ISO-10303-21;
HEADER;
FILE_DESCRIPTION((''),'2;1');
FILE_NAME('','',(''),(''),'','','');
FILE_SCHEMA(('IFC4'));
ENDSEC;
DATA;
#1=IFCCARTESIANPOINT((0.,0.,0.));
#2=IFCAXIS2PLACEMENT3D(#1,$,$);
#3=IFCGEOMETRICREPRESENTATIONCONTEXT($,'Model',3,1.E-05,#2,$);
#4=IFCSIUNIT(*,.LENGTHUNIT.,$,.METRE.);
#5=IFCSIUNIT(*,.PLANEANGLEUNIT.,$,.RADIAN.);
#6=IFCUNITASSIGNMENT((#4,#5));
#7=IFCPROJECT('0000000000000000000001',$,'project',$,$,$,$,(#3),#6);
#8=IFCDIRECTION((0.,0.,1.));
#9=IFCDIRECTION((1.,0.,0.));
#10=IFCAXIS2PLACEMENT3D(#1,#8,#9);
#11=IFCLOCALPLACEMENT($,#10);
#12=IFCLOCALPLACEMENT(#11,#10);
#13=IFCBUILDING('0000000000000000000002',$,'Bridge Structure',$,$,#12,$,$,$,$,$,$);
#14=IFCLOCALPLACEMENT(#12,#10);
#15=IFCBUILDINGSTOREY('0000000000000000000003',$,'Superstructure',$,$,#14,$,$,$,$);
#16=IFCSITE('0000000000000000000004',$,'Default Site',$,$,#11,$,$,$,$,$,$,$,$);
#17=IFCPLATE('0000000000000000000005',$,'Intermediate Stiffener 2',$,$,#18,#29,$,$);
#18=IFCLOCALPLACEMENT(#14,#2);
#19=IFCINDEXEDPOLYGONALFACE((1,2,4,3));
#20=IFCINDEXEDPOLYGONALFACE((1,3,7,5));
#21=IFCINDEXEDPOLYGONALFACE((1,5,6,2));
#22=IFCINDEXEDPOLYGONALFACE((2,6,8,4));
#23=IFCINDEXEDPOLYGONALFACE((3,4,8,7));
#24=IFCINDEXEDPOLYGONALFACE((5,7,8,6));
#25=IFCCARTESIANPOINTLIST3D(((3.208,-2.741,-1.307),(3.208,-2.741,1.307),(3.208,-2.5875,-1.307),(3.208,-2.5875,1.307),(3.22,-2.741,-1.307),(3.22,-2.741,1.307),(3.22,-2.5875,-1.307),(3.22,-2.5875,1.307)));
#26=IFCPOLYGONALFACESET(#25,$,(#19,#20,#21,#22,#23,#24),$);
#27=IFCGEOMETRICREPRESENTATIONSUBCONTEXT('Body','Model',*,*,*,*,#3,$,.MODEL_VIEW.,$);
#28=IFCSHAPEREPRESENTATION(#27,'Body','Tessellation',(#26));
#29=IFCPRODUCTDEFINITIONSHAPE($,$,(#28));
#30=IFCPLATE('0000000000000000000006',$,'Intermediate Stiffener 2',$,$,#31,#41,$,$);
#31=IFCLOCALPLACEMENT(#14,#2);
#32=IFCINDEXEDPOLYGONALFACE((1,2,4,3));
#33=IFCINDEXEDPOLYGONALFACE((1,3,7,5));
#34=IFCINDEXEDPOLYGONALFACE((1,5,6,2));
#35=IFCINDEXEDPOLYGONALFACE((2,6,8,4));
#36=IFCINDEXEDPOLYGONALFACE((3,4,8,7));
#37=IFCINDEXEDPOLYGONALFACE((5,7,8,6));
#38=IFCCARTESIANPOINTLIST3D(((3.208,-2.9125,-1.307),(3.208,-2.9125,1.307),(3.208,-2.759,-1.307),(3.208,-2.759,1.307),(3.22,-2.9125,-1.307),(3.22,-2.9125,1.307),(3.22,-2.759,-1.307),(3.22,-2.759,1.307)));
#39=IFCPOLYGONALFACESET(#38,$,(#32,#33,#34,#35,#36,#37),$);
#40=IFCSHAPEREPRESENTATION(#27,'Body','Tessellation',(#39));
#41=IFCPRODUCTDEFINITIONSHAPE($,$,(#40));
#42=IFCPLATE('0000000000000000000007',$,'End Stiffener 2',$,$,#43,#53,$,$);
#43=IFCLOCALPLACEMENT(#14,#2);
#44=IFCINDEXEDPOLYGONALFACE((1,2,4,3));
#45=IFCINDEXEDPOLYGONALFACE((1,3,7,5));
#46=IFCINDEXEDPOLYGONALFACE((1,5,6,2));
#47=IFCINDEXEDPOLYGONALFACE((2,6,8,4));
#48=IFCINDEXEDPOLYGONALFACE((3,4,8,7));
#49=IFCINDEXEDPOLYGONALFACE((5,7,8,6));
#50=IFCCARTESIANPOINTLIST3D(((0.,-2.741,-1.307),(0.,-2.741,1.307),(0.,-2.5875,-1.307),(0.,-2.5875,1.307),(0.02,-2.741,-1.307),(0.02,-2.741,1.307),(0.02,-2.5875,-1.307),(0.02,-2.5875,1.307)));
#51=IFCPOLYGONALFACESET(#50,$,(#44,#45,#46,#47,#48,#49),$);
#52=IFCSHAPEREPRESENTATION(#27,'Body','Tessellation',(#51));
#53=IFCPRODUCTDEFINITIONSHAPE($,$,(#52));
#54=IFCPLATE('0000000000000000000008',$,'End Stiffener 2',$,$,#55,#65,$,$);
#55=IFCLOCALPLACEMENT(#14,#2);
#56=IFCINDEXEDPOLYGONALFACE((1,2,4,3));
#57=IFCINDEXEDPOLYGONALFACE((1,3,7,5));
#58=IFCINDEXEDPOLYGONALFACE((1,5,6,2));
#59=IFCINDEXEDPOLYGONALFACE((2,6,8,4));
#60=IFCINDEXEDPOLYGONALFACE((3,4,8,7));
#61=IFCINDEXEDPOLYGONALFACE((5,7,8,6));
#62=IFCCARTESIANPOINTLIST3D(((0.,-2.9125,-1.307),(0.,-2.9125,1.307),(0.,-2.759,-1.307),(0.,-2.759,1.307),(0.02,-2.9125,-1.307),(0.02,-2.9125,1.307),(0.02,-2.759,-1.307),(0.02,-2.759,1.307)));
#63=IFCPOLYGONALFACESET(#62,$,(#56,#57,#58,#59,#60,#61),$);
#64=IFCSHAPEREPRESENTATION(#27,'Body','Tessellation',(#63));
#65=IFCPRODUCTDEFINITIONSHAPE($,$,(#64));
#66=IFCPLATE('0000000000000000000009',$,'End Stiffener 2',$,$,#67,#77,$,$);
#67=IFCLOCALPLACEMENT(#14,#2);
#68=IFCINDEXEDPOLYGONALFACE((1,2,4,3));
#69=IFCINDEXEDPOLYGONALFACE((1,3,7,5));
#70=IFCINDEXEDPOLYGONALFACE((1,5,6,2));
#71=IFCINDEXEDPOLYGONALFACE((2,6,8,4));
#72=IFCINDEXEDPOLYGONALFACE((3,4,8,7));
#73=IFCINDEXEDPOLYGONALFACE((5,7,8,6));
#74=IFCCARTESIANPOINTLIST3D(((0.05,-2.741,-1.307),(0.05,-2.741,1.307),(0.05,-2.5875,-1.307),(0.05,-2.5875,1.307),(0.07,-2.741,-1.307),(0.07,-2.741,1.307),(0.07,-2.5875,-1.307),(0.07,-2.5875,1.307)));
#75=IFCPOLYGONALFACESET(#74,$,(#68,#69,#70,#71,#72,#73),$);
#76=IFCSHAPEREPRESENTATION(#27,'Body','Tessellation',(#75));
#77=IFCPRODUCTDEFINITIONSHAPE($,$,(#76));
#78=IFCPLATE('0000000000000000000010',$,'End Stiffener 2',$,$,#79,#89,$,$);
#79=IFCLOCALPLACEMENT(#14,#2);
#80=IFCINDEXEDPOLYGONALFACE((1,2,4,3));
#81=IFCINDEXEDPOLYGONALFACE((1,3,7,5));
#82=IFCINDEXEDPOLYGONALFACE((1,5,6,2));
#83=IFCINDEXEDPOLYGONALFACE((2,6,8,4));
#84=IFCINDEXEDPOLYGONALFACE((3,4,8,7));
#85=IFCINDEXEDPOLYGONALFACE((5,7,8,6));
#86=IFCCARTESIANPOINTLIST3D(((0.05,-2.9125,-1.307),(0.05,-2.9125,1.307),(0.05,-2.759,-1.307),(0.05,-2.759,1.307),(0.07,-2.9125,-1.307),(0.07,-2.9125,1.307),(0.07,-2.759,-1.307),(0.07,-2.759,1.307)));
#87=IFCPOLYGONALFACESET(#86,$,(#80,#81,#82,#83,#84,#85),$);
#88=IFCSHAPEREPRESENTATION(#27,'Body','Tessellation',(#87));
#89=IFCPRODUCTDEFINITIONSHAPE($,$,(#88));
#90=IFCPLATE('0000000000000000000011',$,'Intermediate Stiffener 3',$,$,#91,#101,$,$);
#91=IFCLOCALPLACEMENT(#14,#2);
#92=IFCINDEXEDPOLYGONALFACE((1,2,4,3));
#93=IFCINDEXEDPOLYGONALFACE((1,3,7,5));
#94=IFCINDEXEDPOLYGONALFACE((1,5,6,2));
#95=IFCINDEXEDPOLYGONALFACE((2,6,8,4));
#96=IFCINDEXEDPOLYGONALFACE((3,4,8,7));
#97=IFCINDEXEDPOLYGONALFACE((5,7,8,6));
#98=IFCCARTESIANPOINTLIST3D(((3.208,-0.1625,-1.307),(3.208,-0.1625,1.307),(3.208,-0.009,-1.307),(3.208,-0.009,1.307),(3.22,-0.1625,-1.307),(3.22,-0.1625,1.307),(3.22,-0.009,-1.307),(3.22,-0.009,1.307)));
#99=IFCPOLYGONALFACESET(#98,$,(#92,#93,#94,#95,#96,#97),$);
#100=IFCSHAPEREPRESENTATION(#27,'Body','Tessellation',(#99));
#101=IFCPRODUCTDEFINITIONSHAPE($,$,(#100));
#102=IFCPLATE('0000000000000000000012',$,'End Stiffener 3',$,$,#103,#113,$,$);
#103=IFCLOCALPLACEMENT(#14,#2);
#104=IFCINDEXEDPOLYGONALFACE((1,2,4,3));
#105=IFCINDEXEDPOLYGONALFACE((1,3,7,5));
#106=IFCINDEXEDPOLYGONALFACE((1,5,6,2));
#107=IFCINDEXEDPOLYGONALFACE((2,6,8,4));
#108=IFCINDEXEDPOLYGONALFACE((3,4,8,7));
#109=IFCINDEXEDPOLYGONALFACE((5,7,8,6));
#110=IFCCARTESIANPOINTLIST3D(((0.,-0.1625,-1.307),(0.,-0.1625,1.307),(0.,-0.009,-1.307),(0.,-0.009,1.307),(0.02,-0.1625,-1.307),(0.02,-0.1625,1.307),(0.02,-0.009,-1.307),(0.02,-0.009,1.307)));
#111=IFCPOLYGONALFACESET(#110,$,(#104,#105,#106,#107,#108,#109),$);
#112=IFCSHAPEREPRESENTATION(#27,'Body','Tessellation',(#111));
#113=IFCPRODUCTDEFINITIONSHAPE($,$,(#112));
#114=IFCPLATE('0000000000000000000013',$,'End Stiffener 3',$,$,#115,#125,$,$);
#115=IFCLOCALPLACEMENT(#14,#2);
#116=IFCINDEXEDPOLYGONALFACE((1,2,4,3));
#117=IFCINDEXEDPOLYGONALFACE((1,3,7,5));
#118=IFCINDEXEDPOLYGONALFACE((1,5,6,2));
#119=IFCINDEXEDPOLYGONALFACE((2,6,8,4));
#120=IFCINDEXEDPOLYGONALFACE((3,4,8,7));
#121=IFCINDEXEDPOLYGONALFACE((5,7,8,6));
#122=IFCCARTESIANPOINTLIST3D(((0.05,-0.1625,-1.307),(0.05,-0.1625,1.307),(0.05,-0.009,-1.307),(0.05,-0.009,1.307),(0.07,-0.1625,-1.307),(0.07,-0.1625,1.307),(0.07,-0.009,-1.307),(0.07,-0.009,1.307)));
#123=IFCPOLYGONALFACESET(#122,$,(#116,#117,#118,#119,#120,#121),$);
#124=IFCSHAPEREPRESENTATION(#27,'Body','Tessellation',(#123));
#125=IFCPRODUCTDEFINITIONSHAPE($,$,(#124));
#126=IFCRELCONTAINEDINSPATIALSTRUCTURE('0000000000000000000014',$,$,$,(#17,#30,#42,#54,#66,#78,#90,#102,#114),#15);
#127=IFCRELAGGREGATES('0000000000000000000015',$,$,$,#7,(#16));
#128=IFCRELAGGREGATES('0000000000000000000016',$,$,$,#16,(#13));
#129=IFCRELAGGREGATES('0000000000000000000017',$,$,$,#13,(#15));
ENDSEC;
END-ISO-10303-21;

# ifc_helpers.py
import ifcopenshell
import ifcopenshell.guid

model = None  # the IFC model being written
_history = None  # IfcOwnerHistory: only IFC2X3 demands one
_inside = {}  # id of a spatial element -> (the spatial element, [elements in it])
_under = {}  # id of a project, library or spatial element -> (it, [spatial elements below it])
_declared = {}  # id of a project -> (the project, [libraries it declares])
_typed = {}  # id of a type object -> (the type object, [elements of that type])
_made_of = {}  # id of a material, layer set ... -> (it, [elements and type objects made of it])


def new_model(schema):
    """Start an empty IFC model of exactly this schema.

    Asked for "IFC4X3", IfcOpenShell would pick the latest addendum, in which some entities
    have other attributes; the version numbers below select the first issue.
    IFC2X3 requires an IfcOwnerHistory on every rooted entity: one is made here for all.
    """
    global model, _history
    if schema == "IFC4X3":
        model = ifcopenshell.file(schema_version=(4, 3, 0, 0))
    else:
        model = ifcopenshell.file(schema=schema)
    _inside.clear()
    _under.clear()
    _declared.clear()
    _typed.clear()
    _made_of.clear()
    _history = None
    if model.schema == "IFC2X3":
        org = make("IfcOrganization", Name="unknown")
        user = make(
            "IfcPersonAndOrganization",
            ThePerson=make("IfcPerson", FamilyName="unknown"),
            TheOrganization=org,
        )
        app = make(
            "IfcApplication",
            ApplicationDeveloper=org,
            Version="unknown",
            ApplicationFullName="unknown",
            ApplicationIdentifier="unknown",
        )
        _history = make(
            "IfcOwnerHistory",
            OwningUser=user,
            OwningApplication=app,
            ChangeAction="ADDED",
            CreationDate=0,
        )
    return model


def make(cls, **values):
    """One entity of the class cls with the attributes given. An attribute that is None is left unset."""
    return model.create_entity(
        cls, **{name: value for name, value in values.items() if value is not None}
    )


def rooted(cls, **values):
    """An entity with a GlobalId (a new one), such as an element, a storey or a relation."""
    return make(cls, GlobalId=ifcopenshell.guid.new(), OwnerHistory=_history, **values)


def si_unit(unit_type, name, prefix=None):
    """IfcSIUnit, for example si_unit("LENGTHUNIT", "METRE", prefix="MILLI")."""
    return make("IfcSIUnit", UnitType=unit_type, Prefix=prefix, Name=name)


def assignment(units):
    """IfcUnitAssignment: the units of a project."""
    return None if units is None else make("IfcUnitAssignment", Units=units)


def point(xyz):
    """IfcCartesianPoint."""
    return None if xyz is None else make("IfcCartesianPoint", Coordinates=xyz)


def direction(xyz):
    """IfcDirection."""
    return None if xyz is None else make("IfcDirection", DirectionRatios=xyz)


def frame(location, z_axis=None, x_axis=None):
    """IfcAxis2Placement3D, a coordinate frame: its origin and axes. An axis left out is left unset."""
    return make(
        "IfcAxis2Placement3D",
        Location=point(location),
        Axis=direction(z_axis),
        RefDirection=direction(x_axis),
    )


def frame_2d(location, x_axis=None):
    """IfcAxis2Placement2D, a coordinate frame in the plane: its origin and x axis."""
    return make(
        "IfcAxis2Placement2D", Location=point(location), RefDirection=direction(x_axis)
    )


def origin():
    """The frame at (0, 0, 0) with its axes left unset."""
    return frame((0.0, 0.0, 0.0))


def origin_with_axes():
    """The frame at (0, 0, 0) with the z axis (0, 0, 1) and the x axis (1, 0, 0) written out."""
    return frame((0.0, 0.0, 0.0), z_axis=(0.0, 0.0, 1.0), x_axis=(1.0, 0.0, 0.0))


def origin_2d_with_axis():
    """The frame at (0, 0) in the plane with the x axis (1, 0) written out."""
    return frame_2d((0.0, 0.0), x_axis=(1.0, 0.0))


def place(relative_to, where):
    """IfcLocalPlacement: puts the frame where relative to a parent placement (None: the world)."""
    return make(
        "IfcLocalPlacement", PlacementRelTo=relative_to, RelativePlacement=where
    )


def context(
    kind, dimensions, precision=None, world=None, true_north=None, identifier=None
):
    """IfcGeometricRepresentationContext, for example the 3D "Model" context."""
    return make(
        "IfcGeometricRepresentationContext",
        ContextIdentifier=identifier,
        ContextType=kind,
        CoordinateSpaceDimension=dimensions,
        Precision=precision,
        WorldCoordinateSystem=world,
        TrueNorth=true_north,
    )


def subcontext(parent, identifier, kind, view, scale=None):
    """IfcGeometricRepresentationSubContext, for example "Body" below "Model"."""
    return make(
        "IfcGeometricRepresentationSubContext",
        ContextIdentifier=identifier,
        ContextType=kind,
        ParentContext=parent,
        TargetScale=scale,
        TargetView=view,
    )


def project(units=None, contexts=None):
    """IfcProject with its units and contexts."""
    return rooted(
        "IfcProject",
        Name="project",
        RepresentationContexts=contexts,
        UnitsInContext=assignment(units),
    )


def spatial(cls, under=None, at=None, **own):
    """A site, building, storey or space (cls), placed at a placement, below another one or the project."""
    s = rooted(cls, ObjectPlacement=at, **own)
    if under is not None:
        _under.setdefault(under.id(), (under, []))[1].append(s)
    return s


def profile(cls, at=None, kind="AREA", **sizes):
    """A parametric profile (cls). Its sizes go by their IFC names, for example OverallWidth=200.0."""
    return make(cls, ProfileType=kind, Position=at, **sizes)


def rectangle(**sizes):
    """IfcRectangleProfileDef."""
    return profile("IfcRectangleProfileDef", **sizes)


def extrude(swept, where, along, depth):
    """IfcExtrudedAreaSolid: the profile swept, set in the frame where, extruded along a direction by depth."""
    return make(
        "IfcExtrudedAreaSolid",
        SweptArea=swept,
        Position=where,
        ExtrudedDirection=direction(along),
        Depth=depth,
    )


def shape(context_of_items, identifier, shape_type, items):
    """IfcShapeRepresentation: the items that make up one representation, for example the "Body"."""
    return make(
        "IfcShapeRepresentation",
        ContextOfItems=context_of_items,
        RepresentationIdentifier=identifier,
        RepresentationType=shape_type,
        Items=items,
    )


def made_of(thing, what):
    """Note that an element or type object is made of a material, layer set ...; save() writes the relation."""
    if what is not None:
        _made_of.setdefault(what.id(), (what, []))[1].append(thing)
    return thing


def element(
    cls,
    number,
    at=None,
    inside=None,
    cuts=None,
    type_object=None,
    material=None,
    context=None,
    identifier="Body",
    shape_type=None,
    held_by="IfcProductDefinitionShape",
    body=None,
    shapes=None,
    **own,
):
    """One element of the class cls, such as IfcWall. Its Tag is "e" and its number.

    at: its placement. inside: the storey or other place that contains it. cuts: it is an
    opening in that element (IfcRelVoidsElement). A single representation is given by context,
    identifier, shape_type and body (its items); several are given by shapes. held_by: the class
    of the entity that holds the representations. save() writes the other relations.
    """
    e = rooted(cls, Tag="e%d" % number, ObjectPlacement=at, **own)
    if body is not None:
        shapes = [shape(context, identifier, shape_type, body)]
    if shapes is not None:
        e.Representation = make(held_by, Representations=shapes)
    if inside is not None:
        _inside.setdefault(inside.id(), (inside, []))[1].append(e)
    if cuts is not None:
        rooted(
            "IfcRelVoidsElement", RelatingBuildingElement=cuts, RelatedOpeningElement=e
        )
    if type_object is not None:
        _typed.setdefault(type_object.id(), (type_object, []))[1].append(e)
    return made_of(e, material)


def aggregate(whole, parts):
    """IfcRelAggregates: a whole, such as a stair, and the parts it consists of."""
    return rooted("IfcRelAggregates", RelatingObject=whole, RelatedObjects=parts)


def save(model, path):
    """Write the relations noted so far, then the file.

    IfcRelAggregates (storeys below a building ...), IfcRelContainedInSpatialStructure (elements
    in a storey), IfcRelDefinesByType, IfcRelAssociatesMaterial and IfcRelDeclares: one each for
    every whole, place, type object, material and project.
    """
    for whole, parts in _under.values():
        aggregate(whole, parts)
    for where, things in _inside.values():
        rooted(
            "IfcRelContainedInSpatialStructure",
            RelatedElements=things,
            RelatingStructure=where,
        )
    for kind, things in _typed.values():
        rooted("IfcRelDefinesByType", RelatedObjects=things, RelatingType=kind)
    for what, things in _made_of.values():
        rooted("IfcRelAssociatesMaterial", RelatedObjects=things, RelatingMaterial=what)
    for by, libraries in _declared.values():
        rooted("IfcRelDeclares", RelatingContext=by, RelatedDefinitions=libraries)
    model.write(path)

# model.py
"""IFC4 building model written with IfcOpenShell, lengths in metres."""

from ifc_helpers import new_model, si_unit, frame, origin, origin_with_axes, origin_2d_with_axis, place, context, subcontext, project, spatial, rectangle, extrude, element, save


model = new_model("IFC4")

# Units and contexts
model_context = context("Model", 3, precision=1e-05, world=origin())
body_context = subcontext(model_context, "Body", "Model", "MODEL_VIEW")
ifc_project = project(units=[si_unit("LENGTHUNIT", "METRE"), si_unit("PLANEANGLEUNIT", "RADIAN")], contexts=[model_context])

# Site, building, storey
site_placement = place(None, origin_with_axes())
site = spatial("IfcSite", under=ifc_project, at=site_placement, Name="Default Site")
building_placement = place(site_placement, origin_with_axes())
building = spatial("IfcBuilding", under=site, at=building_placement, Name="Bridge Structure")
storey_placement = place(building_placement, origin_with_axes())
storey = spatial("IfcBuildingStorey", under=building, at=storey_placement, Name="Superstructure")

# Plates
for number, where, z_axis, x_axis, name in (
    (1, (3.214, -2.6643, -1.307), (0.0, 0.0, 1.0), (1.0, 0.0, 0.0), "Intermediate Stiffener 2"),
    (2, (3.214, -2.8357, -1.307), (0.0, 0.0, 1.0), (1.0, 0.0, 0.0), "Intermediate Stiffener 2"),
):
    element("IfcPlate", number, at=place(storey_placement, frame(where, z_axis=z_axis, x_axis=x_axis)), inside=storey, Name=name, context=body_context, shape_type="SweptSolid", body=[
        extrude(rectangle(XDim=0.012, YDim=0.1535, at=origin_2d_with_axis()), origin_with_axes(), (0.0, 0.0, 1.0), 2.614),
    ])
for number, where, z_axis, x_axis, name in (
    (3, (0.01, -2.6643, -1.307), (0.0, 0.0, 1.0), (1.0, 0.0, 0.0), "End Stiffener 2"),
    (4, (0.01, -2.8357, -1.307), (0.0, 0.0, 1.0), (1.0, 0.0, 0.0), "End Stiffener 2"),
    (5, (0.06, -2.6643, -1.307), (0.0, 0.0, 1.0), (1.0, 0.0, 0.0), "End Stiffener 2"),
    (6, (0.06, -2.8357, -1.307), (0.0, 0.0, 1.0), (1.0, 0.0, 0.0), "End Stiffener 2"),
):
    element("IfcPlate", number, at=place(storey_placement, frame(where, z_axis=z_axis, x_axis=x_axis)), inside=storey, Name=name, context=body_context, shape_type="SweptSolid", body=[
        extrude(rectangle(XDim=0.02, YDim=0.1535, at=origin_2d_with_axis()), origin_with_axes(), (0.0, 0.0, 1.0), 2.614),
    ])
plate_1_placement = place(storey_placement, frame((3.214, -0.0858, -1.307), z_axis=(0.0, 0.0, 1.0), x_axis=(1.0, 0.0, 0.0)))
element("IfcPlate", 7, at=plate_1_placement, inside=storey, Name="Intermediate Stiffener 3", context=body_context, shape_type="SweptSolid", body=[
    extrude(rectangle(XDim=0.012, YDim=0.1535, at=origin_2d_with_axis()), origin_with_axes(), (0.0, 0.0, 1.0), 2.614),
])
for number, where, z_axis, x_axis, name in (
    (8, (0.01, -0.0858, -1.307), (0.0, 0.0, 1.0), (1.0, 0.0, 0.0), "End Stiffener 3"),
    (9, (0.06, -0.0858, -1.307), (0.0, 0.0, 1.0), (1.0, 0.0, 0.0), "End Stiffener 3"),
):
    element("IfcPlate", number, at=place(storey_placement, frame(where, z_axis=z_axis, x_axis=x_axis)), inside=storey, Name=name, context=body_context, shape_type="SweptSolid", body=[
        extrude(rectangle(XDim=0.02, YDim=0.1535, at=origin_2d_with_axis()), origin_with_axes(), (0.0, 0.0, 1.0), 2.614),
    ])

save(model, "model.ifc")
